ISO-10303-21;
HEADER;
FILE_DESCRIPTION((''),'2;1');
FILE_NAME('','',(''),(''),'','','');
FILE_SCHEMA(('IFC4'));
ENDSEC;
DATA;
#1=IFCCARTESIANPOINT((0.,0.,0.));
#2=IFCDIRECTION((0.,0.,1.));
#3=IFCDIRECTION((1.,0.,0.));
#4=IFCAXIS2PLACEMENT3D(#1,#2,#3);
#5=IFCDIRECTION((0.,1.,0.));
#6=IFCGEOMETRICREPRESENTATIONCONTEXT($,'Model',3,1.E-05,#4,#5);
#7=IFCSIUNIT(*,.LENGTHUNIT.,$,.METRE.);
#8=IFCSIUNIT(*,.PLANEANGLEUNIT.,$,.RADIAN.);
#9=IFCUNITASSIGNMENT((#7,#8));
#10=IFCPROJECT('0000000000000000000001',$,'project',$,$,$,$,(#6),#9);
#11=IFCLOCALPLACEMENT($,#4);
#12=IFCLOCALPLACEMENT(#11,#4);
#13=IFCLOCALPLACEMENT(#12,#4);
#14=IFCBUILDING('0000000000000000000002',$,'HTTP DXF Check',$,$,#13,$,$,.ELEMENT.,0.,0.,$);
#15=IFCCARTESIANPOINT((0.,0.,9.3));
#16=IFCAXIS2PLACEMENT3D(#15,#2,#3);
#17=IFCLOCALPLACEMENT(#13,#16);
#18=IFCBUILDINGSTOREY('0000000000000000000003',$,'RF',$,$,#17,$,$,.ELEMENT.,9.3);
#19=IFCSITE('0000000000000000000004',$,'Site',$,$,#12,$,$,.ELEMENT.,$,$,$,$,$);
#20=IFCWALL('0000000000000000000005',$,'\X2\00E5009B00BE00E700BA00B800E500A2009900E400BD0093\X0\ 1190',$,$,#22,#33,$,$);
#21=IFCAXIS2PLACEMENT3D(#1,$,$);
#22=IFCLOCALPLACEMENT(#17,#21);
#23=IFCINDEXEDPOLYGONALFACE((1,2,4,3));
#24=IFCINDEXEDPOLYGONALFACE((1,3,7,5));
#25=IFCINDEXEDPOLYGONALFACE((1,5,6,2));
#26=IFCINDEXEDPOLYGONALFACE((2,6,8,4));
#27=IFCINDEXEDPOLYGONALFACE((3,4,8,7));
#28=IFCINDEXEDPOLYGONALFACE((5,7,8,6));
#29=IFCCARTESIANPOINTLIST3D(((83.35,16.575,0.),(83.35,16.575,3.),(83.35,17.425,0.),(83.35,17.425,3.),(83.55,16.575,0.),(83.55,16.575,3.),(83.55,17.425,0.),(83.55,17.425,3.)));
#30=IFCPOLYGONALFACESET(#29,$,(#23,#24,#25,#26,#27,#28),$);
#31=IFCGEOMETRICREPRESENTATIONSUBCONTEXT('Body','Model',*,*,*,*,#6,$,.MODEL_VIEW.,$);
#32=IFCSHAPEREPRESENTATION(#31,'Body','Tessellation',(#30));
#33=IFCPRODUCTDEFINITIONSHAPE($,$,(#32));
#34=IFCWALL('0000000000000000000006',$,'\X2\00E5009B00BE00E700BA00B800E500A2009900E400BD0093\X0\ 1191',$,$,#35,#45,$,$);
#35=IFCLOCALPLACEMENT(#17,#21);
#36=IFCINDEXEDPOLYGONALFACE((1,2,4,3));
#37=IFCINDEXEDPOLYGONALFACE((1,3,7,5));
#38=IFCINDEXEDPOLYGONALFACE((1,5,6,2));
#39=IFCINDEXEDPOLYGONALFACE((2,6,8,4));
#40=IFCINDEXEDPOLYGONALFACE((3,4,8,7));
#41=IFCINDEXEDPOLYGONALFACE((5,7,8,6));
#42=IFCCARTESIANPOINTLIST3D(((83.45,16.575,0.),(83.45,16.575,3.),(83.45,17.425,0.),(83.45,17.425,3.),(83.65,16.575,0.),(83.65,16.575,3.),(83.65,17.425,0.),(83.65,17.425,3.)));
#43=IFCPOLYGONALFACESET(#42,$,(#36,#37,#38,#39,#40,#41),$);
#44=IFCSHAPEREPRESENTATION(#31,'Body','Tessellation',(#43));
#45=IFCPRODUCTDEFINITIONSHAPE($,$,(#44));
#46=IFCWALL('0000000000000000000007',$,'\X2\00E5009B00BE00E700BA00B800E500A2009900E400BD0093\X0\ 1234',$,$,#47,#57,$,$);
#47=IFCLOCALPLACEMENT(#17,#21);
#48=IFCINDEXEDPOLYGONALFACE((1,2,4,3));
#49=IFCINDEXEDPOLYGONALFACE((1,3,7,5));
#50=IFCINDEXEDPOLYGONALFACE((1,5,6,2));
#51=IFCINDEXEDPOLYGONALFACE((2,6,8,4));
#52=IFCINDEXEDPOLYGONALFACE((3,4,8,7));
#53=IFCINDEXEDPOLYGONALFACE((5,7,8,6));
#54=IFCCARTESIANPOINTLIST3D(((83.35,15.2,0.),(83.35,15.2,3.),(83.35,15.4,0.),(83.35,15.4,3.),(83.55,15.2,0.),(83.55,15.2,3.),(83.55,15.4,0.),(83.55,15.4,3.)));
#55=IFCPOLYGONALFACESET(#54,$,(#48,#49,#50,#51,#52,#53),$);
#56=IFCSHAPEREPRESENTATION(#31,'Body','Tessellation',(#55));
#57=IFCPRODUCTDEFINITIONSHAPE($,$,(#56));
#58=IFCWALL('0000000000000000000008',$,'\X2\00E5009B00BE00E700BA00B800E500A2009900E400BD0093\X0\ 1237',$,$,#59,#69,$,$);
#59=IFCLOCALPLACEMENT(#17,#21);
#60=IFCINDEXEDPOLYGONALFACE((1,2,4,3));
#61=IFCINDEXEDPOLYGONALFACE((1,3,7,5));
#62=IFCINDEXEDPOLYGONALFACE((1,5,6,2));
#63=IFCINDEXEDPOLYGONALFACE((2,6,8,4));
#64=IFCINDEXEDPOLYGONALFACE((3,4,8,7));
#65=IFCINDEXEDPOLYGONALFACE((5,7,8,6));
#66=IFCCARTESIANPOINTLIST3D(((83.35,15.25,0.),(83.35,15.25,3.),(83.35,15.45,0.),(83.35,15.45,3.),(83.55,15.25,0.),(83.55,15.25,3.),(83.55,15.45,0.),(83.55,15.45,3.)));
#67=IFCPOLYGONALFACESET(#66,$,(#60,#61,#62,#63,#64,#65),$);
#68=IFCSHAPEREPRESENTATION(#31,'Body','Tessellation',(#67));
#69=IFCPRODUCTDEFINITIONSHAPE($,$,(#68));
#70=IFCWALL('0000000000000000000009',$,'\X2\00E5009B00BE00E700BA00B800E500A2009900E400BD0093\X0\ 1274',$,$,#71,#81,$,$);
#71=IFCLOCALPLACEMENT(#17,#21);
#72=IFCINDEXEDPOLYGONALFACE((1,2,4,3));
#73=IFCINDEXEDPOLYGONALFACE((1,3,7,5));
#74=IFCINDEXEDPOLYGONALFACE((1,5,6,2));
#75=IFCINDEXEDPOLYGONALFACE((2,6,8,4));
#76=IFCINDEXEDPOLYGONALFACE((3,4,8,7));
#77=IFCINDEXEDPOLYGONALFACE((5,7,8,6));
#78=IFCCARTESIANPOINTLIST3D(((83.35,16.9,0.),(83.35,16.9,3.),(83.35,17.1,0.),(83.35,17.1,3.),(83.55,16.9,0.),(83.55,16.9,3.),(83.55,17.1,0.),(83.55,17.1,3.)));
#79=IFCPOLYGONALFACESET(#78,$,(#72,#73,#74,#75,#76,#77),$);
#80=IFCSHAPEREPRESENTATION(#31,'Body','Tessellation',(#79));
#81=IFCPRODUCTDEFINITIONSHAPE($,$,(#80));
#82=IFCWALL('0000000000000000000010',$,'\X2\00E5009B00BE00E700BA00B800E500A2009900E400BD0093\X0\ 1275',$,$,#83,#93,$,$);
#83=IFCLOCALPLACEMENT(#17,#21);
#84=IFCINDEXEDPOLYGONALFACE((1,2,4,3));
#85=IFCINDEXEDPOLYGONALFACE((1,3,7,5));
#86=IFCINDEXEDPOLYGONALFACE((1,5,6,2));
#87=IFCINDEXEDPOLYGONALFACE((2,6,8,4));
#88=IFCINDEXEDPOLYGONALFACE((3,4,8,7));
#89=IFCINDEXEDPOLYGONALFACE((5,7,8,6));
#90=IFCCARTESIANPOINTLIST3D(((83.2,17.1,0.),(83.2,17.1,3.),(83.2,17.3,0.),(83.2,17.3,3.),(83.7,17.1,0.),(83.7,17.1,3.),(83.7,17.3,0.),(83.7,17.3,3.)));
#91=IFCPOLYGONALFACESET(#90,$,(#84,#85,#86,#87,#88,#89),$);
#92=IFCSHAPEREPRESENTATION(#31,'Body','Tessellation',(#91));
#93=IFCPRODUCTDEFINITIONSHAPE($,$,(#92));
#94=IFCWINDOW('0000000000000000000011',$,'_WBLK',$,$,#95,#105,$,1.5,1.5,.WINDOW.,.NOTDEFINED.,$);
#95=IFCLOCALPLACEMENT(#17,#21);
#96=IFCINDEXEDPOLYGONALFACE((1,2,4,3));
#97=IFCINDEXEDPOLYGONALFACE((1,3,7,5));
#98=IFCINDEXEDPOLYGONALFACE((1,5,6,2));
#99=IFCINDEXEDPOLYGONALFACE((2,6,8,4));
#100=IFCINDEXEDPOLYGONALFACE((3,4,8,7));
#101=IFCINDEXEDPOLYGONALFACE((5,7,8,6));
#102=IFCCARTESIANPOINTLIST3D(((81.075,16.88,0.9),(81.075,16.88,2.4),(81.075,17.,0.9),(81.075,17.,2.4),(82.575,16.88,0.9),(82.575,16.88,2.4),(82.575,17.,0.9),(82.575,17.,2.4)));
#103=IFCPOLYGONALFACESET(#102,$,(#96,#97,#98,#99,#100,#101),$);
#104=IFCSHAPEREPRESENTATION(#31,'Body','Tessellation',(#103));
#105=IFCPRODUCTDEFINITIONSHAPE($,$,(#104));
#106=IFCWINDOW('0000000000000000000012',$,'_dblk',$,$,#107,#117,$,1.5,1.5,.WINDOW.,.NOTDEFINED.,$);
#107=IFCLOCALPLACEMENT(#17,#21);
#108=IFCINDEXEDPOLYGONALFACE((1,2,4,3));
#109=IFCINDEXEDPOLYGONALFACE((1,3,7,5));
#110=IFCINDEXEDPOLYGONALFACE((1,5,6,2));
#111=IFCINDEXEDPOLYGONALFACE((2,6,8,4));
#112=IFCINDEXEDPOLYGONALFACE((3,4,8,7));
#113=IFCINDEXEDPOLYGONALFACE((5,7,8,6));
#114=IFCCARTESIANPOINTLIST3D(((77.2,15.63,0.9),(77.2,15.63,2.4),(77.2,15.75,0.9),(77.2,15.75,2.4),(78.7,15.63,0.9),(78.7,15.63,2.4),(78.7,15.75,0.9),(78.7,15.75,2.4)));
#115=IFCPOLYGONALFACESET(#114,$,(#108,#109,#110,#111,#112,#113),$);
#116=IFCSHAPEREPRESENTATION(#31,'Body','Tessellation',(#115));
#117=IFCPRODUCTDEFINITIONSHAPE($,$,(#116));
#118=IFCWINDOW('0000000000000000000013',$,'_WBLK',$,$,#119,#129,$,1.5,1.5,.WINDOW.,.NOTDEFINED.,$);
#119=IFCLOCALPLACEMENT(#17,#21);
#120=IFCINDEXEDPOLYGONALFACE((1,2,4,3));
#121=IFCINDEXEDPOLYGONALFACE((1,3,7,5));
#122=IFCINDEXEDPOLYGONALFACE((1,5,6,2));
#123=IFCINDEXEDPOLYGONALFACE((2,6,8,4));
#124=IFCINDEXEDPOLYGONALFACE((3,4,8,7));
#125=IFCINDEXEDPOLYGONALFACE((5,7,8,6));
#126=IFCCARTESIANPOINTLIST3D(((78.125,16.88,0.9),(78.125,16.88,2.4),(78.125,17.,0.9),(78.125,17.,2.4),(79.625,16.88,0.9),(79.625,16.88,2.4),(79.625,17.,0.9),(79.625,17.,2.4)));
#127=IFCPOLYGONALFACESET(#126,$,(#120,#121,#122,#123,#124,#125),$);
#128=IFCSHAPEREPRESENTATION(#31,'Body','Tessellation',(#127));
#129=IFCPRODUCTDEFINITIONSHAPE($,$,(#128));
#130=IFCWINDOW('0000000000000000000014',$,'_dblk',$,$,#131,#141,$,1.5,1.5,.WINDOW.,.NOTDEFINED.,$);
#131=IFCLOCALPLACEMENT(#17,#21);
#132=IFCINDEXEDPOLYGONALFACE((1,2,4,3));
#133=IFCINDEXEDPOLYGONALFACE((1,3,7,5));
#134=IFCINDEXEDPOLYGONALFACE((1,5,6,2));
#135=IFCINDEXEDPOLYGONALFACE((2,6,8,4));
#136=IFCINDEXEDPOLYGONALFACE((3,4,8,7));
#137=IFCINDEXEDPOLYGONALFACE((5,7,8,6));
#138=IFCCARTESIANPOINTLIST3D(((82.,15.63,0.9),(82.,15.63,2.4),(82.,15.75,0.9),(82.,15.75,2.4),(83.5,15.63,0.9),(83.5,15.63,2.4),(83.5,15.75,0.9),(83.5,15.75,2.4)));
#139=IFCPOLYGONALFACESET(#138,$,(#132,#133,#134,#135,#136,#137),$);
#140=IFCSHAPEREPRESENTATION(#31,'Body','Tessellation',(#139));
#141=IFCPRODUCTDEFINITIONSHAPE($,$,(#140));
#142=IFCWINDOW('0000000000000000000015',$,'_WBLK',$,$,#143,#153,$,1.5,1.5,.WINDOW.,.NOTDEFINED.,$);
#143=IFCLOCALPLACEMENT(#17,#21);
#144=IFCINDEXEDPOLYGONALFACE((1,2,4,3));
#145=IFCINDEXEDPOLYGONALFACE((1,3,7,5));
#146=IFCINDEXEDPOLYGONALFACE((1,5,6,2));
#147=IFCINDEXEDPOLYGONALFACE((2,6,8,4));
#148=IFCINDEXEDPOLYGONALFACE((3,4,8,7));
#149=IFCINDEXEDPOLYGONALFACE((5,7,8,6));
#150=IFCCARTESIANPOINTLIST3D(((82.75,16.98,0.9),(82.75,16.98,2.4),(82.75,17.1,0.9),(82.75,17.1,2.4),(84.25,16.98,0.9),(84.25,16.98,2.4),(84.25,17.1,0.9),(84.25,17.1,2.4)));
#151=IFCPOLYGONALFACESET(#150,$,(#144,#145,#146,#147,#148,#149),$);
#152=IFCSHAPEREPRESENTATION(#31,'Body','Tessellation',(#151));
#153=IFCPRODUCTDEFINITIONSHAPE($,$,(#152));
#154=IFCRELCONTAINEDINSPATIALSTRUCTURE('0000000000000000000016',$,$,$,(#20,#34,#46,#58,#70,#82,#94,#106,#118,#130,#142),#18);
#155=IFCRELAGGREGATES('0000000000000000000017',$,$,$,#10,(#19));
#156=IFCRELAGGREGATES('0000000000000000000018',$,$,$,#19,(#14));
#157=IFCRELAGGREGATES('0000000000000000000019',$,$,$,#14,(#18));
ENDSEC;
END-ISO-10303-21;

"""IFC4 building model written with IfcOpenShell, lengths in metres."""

from ifc_helpers import new_model, si_unit, direction, frame, frame_2d, origin_with_axes, place, context, subcontext, project, spatial, rectangle, extrude, element, save


model = new_model("IFC4")

# Units and contexts
model_context = context("Model", 3, precision=1e-05, world=origin_with_axes(), true_north=direction((0.0, 1.0, 0.0)))
body_context = subcontext(model_context, "Body", "Model", "MODEL_VIEW")
ifc_project = project(units=[si_unit("LENGTHUNIT", "METRE"), si_unit("PLANEANGLEUNIT", "RADIAN")], contexts=[model_context])

# Site, building, storey
placement = place(None, origin_with_axes())
site_placement = place(placement, origin_with_axes())
site = spatial("IfcSite", under=ifc_project, at=site_placement, Name="Site", CompositionType="ELEMENT")
building_placement = place(site_placement, origin_with_axes())
building = spatial("IfcBuilding", under=site, at=building_placement, Name="HTTP DXF Check", CompositionType="ELEMENT", ElevationOfRefHeight=0.0, ElevationOfTerrain=0.0)
storey_placement = place(building_placement, frame((0.0, 0.0, 9.3), z_axis=(0.0, 0.0, 1.0), x_axis=(1.0, 0.0, 0.0)))
storey = spatial("IfcBuildingStorey", under=building, at=storey_placement, Name="RF", CompositionType="ELEMENT", Elevation=9.3)

# Walls
for number, where, z_axis, x_axis, name in (
    (1, (83.45, 17.0, 0.0), (0.0, 0.0, 1.0), (0.0, -1.0, 0.0), "å\u009b¾çº¸å¢\u0099ä½\u0093 1190"),
    (2, (83.55, 17.0, 0.0), (0.0, 0.0, 1.0), (0.0, -1.0, 0.0), "å\u009b¾çº¸å¢\u0099ä½\u0093 1191"),
):
    element("IfcWall", number, at=place(storey_placement, frame(where, z_axis=z_axis, x_axis=x_axis)), inside=storey, Name=name, context=body_context, shape_type="SweptSolid", body=[
        extrude(rectangle(XDim=0.85, YDim=0.2, at=frame_2d((0.0, 0.0), x_axis=(1.0, 0.0, 0.0))), frame((0.0, 0.0, 0.0), z_axis=(0.0, 0.0, 1.0)), (0.0, 0.0, 1.0), 3.0),
    ])
for number, where, z_axis, x_axis, name in (
    (3, (83.45, 15.3, 0.0), (0.0, 0.0, 1.0), (0.0, -1.0, 0.0), "å\u009b¾çº¸å¢\u0099ä½\u0093 1234"),
    (4, (83.45, 15.35, 0.0), (0.0, 0.0, 1.0), (0.0, -1.0, 0.0), "å\u009b¾çº¸å¢\u0099ä½\u0093 1237"),
    (5, (83.45, 17.0, 0.0), (0.0, 0.0, 1.0), (0.0, 1.0, 0.0), "å\u009b¾çº¸å¢\u0099ä½\u0093 1274"),
):
    element("IfcWall", number, at=place(storey_placement, frame(where, z_axis=z_axis, x_axis=x_axis)), inside=storey, Name=name, context=body_context, shape_type="SweptSolid", body=[
        extrude(rectangle(XDim=0.2, YDim=0.2, at=frame_2d((0.0, 0.0), x_axis=(1.0, 0.0, 0.0))), frame((0.0, 0.0, 0.0), z_axis=(0.0, 0.0, 1.0)), (0.0, 0.0, 1.0), 3.0),
    ])
wall_1_placement = place(storey_placement, frame((83.45, 17.2, 0.0), z_axis=(0.0, 0.0, 1.0), x_axis=(1.0, 0.0, 0.0)))
element("IfcWall", 6, at=wall_1_placement, inside=storey, Name="å\u009b¾çº¸å¢\u0099ä½\u0093 1275", context=body_context, shape_type="SweptSolid", body=[
    extrude(rectangle(XDim=0.5, YDim=0.2, at=frame_2d((0.0, 0.0), x_axis=(1.0, 0.0, 0.0))), frame((0.0, 0.0, 0.0), z_axis=(0.0, 0.0, 1.0)), (0.0, 0.0, 1.0), 3.0),
])

# Windows
for number, where, z_axis, x_axis, name in (
    (7, (81.825, 16.94, 0.9), (0.0, 0.0, 1.0), (1.0, 0.0, 0.0), "_WBLK"),
    (8, (77.95, 15.69, 0.9), (0.0, 0.0, 1.0), (1.0, 0.0, 0.0), "_dblk"),
    (9, (78.875, 16.94, 0.9), (0.0, 0.0, 1.0), (1.0, 0.0, 0.0), "_WBLK"),
    (10, (82.75, 15.69, 0.9), (0.0, 0.0, 1.0), (1.0, 0.0, 0.0), "_dblk"),
    (11, (83.5, 17.04, 0.9), (0.0, 0.0, 1.0), (1.0, 0.0, 0.0), "_WBLK"),
):
    element("IfcWindow", number, at=place(storey_placement, frame(where, z_axis=z_axis, x_axis=x_axis)), inside=storey, Name=name, OverallHeight=1.5, OverallWidth=1.5, PartitioningType="NOTDEFINED", PredefinedType="WINDOW", context=body_context, shape_type="SweptSolid", body=[
        extrude(rectangle(XDim=1.5, YDim=0.12, at=frame_2d((0.0, 0.0), x_axis=(1.0, 0.0, 0.0))), frame((0.0, 0.0, 0.0), z_axis=(0.0, 0.0, 1.0)), (0.0, 0.0, 1.0), 1.5),
    ])

save(model, "model.ifc")
